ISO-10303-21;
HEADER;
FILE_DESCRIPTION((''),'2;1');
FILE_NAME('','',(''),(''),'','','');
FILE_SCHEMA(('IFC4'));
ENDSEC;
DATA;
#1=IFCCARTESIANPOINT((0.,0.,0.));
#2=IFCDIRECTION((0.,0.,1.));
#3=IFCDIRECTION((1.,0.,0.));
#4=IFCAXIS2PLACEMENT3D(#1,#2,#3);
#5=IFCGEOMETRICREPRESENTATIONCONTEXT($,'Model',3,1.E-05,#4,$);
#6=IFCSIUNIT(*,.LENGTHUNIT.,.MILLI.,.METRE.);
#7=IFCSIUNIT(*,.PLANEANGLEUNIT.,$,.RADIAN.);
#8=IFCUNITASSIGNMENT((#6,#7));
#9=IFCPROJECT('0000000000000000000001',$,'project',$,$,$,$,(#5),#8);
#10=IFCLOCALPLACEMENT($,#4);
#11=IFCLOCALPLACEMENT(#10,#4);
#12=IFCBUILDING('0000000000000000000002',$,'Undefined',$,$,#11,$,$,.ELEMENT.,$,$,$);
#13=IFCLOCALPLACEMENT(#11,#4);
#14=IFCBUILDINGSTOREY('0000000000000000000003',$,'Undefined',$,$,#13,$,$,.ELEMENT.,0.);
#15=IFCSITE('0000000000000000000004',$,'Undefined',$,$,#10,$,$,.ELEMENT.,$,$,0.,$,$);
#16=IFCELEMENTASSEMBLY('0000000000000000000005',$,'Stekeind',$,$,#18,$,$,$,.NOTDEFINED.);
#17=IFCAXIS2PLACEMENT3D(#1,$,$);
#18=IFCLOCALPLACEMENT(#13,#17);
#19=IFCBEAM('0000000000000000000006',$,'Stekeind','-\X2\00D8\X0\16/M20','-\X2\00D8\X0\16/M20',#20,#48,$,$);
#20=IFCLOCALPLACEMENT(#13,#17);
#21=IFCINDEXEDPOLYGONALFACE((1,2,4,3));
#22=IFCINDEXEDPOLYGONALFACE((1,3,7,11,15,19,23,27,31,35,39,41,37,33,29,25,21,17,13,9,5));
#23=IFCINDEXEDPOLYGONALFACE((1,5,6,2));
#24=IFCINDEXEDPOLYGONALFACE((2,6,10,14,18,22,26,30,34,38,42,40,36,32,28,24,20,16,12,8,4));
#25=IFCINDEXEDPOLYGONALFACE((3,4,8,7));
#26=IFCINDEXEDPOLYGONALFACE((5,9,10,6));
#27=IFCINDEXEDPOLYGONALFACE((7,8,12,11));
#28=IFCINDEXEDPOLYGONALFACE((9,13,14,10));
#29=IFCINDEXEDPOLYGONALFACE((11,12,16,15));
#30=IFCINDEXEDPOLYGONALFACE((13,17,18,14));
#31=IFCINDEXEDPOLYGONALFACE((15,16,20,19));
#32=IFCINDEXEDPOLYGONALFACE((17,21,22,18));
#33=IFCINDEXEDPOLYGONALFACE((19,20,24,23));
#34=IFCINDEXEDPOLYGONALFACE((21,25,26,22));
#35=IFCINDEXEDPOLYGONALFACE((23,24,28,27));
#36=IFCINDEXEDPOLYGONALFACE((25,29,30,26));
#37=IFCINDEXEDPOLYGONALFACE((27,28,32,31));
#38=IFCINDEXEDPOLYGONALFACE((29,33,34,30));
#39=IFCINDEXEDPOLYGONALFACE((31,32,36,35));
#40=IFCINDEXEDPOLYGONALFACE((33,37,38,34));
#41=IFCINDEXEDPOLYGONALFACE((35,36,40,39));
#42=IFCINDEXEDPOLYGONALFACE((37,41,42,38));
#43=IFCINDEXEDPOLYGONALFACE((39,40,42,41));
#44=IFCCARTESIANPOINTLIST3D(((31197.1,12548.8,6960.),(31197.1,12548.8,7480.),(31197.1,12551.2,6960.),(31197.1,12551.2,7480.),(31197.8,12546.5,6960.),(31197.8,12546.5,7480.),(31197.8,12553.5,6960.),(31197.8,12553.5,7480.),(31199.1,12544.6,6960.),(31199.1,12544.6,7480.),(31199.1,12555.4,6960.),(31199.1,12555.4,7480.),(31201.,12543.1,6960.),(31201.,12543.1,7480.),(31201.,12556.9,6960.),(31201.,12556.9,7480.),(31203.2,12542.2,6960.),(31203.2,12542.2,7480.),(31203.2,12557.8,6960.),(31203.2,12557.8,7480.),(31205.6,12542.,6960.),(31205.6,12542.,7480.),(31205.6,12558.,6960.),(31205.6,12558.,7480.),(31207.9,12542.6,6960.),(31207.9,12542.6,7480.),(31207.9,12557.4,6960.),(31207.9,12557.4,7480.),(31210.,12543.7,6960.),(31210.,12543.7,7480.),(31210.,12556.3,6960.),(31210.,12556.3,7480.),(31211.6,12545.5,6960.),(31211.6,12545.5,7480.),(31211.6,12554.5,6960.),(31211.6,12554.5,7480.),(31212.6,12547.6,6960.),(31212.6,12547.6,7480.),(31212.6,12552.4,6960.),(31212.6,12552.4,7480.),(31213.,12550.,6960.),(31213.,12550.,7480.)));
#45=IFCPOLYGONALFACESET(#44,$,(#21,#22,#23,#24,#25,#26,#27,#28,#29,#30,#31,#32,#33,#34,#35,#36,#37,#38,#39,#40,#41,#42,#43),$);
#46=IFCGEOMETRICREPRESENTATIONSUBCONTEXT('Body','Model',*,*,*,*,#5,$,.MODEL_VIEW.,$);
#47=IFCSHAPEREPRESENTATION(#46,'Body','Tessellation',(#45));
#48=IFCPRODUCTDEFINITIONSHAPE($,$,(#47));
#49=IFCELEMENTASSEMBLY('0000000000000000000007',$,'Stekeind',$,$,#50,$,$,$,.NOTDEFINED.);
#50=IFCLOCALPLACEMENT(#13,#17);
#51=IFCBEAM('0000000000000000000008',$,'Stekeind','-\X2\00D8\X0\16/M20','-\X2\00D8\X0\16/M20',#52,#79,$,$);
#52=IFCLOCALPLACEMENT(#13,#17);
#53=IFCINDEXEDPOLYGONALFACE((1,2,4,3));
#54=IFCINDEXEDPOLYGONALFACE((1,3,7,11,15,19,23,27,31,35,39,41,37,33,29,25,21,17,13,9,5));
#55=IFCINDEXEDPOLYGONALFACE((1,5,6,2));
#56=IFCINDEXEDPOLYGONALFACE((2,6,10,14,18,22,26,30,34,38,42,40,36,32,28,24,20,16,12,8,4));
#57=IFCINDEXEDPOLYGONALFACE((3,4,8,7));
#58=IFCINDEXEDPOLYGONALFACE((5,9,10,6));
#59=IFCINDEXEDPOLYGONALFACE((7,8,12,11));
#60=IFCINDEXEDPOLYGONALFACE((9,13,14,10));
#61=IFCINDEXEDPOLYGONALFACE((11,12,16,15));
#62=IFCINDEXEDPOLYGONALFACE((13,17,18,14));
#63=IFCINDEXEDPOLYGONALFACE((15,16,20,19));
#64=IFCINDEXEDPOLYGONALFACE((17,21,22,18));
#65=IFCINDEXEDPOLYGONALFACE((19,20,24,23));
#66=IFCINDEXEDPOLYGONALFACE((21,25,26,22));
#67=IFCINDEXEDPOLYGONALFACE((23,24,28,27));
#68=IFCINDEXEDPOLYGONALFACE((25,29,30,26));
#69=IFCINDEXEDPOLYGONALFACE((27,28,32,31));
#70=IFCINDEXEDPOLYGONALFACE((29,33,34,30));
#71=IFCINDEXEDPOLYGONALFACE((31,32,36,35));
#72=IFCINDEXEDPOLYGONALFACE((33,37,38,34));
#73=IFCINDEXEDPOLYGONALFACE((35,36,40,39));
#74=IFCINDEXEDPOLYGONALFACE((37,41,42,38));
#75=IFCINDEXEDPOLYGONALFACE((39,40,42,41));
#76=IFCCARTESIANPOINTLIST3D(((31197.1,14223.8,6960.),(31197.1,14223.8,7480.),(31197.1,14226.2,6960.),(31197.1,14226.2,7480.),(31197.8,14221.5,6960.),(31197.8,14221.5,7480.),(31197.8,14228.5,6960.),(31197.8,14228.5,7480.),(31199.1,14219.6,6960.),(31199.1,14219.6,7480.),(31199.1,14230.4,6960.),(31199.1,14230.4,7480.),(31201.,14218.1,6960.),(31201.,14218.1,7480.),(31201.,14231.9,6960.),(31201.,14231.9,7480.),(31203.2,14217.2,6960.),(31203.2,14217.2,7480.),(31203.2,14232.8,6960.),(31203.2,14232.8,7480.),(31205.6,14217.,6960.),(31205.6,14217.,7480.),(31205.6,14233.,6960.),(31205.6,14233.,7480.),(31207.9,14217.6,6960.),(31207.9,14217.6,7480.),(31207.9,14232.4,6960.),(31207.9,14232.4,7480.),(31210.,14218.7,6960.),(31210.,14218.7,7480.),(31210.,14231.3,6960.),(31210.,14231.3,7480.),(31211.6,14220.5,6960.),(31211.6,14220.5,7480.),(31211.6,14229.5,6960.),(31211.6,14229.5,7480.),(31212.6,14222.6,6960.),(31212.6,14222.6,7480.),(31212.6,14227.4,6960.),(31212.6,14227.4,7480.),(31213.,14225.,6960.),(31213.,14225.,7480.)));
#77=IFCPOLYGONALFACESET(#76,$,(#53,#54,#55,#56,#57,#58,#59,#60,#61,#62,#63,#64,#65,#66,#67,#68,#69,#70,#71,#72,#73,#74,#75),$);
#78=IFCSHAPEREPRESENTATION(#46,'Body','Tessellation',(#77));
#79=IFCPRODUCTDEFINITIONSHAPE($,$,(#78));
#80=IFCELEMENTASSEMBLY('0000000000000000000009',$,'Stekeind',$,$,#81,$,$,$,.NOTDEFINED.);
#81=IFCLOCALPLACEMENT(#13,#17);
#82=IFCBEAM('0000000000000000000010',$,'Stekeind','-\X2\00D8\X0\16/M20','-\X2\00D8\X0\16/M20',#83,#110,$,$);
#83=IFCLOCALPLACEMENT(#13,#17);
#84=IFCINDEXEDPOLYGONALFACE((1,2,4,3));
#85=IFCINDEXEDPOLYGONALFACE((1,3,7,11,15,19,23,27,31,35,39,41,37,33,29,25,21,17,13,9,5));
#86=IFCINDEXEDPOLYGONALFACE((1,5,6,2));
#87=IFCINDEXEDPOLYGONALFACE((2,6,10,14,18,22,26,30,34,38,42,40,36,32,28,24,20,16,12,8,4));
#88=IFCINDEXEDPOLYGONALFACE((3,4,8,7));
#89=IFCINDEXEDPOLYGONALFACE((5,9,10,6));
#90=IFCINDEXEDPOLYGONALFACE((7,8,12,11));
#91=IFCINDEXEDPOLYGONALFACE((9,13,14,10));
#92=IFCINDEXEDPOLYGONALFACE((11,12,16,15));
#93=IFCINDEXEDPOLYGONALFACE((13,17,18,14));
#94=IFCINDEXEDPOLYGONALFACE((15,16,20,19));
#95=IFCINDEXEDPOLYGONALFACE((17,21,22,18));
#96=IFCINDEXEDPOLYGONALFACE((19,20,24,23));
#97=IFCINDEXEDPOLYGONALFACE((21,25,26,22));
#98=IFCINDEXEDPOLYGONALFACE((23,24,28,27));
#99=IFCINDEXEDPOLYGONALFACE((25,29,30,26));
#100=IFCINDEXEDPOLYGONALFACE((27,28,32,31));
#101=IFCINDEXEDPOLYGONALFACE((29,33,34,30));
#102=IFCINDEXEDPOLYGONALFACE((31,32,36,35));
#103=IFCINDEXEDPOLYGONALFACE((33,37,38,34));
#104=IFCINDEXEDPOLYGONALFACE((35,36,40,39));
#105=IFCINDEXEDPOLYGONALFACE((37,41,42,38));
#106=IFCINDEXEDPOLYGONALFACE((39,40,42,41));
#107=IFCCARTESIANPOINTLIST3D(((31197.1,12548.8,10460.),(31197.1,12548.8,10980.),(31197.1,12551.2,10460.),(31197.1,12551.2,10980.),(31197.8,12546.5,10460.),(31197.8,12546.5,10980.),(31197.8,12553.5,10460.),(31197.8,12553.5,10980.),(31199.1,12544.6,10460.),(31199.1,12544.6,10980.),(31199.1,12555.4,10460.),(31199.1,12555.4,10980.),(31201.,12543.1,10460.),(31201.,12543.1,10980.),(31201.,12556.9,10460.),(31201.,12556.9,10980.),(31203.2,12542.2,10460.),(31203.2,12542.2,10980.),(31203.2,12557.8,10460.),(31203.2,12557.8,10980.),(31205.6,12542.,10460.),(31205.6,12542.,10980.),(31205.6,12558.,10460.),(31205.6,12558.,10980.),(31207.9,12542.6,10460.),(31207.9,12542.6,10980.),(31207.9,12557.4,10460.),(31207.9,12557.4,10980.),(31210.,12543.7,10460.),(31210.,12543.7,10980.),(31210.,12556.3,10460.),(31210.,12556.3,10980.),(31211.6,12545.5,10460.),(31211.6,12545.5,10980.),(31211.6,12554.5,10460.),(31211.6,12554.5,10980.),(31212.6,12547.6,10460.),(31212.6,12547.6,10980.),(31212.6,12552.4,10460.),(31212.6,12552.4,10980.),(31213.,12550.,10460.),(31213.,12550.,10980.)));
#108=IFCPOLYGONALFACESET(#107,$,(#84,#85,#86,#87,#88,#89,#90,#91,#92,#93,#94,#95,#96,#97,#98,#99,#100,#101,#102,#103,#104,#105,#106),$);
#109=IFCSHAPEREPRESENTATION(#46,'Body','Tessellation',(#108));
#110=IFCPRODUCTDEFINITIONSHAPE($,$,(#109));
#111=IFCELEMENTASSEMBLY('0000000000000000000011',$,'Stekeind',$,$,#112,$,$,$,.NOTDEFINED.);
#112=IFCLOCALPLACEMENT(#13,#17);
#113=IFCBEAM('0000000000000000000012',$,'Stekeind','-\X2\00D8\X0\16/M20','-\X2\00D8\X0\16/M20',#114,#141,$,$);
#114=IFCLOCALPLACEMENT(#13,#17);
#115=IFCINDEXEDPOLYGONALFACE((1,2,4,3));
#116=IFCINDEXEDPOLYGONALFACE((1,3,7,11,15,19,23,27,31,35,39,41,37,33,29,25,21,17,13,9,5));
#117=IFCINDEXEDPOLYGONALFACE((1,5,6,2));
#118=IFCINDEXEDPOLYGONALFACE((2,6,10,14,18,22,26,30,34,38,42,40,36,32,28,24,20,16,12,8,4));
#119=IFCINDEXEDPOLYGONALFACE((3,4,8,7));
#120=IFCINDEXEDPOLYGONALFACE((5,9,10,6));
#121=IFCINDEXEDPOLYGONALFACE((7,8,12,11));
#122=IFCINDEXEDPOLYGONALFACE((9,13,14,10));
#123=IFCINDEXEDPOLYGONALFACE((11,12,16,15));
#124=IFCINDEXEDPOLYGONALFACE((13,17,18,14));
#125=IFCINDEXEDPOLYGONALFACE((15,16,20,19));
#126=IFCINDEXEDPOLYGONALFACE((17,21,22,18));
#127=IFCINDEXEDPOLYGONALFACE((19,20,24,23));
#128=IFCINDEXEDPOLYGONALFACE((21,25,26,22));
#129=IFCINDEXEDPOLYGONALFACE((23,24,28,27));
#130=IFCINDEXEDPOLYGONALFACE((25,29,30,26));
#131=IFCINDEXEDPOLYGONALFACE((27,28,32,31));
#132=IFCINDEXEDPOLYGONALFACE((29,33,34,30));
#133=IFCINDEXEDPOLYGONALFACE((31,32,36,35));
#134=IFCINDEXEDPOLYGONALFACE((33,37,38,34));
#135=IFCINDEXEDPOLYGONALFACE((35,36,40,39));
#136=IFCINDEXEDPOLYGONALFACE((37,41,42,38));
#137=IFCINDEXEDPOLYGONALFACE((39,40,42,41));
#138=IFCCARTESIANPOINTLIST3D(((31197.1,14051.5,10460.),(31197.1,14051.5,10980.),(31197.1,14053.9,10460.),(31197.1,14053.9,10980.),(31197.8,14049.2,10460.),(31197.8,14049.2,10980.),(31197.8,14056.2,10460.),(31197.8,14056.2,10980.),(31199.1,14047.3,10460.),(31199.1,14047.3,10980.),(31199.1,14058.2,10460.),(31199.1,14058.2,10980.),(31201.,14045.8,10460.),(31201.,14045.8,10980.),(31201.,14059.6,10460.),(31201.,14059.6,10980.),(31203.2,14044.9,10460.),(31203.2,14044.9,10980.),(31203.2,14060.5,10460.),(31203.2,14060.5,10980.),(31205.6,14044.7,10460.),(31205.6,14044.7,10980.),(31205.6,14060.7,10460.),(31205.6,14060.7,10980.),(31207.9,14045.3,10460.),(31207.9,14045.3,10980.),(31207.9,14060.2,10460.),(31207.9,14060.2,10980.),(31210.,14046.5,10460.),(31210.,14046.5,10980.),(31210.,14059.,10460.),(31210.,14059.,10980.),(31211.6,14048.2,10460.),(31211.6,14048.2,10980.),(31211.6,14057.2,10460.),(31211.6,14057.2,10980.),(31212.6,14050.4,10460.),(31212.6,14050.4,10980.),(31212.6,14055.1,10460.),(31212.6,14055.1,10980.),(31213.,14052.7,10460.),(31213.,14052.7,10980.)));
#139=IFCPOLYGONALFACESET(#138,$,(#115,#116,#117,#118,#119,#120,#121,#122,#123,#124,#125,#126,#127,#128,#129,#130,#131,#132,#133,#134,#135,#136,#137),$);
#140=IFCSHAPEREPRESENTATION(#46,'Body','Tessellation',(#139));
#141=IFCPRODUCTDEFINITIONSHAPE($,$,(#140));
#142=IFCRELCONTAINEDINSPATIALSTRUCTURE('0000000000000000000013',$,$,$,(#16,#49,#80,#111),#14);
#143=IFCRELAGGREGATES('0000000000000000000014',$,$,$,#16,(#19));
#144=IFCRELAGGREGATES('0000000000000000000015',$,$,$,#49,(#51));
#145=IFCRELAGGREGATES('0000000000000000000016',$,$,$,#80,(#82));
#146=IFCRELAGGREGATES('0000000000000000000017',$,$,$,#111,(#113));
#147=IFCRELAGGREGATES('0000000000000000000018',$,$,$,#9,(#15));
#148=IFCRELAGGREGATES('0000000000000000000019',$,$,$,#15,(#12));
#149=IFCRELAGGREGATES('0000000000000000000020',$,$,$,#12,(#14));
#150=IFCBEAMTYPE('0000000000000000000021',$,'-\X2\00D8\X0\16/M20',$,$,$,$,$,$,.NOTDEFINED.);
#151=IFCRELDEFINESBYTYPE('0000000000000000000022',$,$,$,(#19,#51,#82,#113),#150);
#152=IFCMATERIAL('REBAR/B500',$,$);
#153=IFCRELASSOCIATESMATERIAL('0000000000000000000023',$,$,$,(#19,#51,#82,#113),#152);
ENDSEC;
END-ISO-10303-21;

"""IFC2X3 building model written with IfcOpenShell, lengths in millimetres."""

from ifc_helpers import new_model, si_unit, frame, origin_with_axes, origin_2d_with_axis, place, context, subcontext, project, spatial, circle, extrude, material, type_object, element, aggregate, save


model = new_model("IFC2X3")

# Units and contexts
model_context = context("Model", 3, precision=1e-05, world=origin_with_axes())
body_context = subcontext(model_context, "Body", "Model", "MODEL_VIEW")
ifc_project = project(units=[si_unit("LENGTHUNIT", "METRE", prefix="MILLI"), si_unit("PLANEANGLEUNIT", "RADIAN")], contexts=[model_context])

# Site, building, storey
site_placement = place(None, origin_with_axes())
site = spatial("IfcSite", under=ifc_project, at=site_placement, Name="Undefined", CompositionType="ELEMENT", RefElevation=0.0)
building_placement = place(site_placement, origin_with_axes())
building = spatial("IfcBuilding", under=site, at=building_placement, Name="Undefined", CompositionType="ELEMENT")
storey_placement = place(building_placement, origin_with_axes())
storey = spatial("IfcBuildingStorey", under=building, at=storey_placement, Name="Undefined", CompositionType="ELEMENT", Elevation=0.0)

# Element assemblies, beams
ifc_material_1 = material(Name="REBAR/B500")
beam_type_1 = type_object("IfcBeamType", Name="-Ø16/M20", PredefinedType="NOTDEFINED")
assembly_1_placement = place(storey_placement, origin_with_axes())
assembly_1 = element("IfcElementAssembly", 1, at=assembly_1_placement, inside=storey, Name="Stekeind", PredefinedType="NOTDEFINED")
beam_1_placement = place(assembly_1_placement, frame((31205.0, 12550.0, 7480.0), z_axis=(0.0, 1.0, 0.0), x_axis=(0.0, 0.0, -1.0)))
beam_1 = element("IfcBeam", 2, at=beam_1_placement, type_object=beam_type_1, material=ifc_material_1, Name="Stekeind", Description="-Ø16/M20", ObjectType="-Ø16/M20", context=body_context, shape_type="SweptSolid", body=[
    extrude(circle(Radius=8.0, at=origin_2d_with_axis()), frame((520.0, 0.0, 0.0), z_axis=(-1.0, 0.0, 0.0), x_axis=(0.0, -1.0, 0.0)), (0.0, 0.0, 1.0), 520.0),
])
aggregate(assembly_1, [beam_1])
assembly_2_placement = place(storey_placement, origin_with_axes())
assembly_2 = element("IfcElementAssembly", 3, at=assembly_2_placement, inside=storey, Name="Stekeind", PredefinedType="NOTDEFINED")
beam_2_placement = place(assembly_2_placement, frame((31205.0, 14225.0, 7480.0), z_axis=(0.0, 1.0, 0.0), x_axis=(0.0, 0.0, -1.0)))
beam_2 = element("IfcBeam", 4, at=beam_2_placement, type_object=beam_type_1, material=ifc_material_1, Name="Stekeind", Description="-Ø16/M20", ObjectType="-Ø16/M20", context=body_context, shape_type="SweptSolid", body=[
    extrude(circle(Radius=8.0, at=origin_2d_with_axis()), frame((520.0, 0.0, 0.0), z_axis=(-1.0, 0.0, 0.0), x_axis=(0.0, -1.0, 0.0)), (0.0, 0.0, 1.0), 520.0),
])
aggregate(assembly_2, [beam_2])
assembly_3_placement = place(storey_placement, origin_with_axes())
assembly_3 = element("IfcElementAssembly", 5, at=assembly_3_placement, inside=storey, Name="Stekeind", PredefinedType="NOTDEFINED")
beam_3_placement = place(assembly_3_placement, frame((31205.0, 12550.0, 10980.0), z_axis=(0.0, 1.0, 0.0), x_axis=(0.0, 0.0, -1.0)))
beam_3 = element("IfcBeam", 6, at=beam_3_placement, type_object=beam_type_1, material=ifc_material_1, Name="Stekeind", Description="-Ø16/M20", ObjectType="-Ø16/M20", context=body_context, shape_type="SweptSolid", body=[
    extrude(circle(Radius=8.0, at=origin_2d_with_axis()), frame((520.0, 0.0, 0.0), z_axis=(-1.0, 0.0, 0.0), x_axis=(0.0, -1.0, 0.0)), (0.0, 0.0, 1.0), 520.0),
])
aggregate(assembly_3, [beam_3])
assembly_4_placement = place(storey_placement, origin_with_axes())
assembly_4 = element("IfcElementAssembly", 7, at=assembly_4_placement, inside=storey, Name="Stekeind", PredefinedType="NOTDEFINED")
beam_4_placement = place(assembly_4_placement, frame((31205.0, 14052.7, 10980.0), z_axis=(0.0, 1.0, 0.0), x_axis=(0.0, 0.0, -1.0)))
beam_4 = element("IfcBeam", 8, at=beam_4_placement, type_object=beam_type_1, material=ifc_material_1, Name="Stekeind", Description="-Ø16/M20", ObjectType="-Ø16/M20", context=body_context, shape_type="SweptSolid", body=[
    extrude(circle(Radius=8.0, at=origin_2d_with_axis()), frame((520.0, 0.0, 0.0), z_axis=(-1.0, 0.0, 0.0), x_axis=(0.0, -1.0, 0.0)), (0.0, 0.0, 1.0), 520.0),
])
aggregate(assembly_4, [beam_4])

save(model, "model.ifc")
